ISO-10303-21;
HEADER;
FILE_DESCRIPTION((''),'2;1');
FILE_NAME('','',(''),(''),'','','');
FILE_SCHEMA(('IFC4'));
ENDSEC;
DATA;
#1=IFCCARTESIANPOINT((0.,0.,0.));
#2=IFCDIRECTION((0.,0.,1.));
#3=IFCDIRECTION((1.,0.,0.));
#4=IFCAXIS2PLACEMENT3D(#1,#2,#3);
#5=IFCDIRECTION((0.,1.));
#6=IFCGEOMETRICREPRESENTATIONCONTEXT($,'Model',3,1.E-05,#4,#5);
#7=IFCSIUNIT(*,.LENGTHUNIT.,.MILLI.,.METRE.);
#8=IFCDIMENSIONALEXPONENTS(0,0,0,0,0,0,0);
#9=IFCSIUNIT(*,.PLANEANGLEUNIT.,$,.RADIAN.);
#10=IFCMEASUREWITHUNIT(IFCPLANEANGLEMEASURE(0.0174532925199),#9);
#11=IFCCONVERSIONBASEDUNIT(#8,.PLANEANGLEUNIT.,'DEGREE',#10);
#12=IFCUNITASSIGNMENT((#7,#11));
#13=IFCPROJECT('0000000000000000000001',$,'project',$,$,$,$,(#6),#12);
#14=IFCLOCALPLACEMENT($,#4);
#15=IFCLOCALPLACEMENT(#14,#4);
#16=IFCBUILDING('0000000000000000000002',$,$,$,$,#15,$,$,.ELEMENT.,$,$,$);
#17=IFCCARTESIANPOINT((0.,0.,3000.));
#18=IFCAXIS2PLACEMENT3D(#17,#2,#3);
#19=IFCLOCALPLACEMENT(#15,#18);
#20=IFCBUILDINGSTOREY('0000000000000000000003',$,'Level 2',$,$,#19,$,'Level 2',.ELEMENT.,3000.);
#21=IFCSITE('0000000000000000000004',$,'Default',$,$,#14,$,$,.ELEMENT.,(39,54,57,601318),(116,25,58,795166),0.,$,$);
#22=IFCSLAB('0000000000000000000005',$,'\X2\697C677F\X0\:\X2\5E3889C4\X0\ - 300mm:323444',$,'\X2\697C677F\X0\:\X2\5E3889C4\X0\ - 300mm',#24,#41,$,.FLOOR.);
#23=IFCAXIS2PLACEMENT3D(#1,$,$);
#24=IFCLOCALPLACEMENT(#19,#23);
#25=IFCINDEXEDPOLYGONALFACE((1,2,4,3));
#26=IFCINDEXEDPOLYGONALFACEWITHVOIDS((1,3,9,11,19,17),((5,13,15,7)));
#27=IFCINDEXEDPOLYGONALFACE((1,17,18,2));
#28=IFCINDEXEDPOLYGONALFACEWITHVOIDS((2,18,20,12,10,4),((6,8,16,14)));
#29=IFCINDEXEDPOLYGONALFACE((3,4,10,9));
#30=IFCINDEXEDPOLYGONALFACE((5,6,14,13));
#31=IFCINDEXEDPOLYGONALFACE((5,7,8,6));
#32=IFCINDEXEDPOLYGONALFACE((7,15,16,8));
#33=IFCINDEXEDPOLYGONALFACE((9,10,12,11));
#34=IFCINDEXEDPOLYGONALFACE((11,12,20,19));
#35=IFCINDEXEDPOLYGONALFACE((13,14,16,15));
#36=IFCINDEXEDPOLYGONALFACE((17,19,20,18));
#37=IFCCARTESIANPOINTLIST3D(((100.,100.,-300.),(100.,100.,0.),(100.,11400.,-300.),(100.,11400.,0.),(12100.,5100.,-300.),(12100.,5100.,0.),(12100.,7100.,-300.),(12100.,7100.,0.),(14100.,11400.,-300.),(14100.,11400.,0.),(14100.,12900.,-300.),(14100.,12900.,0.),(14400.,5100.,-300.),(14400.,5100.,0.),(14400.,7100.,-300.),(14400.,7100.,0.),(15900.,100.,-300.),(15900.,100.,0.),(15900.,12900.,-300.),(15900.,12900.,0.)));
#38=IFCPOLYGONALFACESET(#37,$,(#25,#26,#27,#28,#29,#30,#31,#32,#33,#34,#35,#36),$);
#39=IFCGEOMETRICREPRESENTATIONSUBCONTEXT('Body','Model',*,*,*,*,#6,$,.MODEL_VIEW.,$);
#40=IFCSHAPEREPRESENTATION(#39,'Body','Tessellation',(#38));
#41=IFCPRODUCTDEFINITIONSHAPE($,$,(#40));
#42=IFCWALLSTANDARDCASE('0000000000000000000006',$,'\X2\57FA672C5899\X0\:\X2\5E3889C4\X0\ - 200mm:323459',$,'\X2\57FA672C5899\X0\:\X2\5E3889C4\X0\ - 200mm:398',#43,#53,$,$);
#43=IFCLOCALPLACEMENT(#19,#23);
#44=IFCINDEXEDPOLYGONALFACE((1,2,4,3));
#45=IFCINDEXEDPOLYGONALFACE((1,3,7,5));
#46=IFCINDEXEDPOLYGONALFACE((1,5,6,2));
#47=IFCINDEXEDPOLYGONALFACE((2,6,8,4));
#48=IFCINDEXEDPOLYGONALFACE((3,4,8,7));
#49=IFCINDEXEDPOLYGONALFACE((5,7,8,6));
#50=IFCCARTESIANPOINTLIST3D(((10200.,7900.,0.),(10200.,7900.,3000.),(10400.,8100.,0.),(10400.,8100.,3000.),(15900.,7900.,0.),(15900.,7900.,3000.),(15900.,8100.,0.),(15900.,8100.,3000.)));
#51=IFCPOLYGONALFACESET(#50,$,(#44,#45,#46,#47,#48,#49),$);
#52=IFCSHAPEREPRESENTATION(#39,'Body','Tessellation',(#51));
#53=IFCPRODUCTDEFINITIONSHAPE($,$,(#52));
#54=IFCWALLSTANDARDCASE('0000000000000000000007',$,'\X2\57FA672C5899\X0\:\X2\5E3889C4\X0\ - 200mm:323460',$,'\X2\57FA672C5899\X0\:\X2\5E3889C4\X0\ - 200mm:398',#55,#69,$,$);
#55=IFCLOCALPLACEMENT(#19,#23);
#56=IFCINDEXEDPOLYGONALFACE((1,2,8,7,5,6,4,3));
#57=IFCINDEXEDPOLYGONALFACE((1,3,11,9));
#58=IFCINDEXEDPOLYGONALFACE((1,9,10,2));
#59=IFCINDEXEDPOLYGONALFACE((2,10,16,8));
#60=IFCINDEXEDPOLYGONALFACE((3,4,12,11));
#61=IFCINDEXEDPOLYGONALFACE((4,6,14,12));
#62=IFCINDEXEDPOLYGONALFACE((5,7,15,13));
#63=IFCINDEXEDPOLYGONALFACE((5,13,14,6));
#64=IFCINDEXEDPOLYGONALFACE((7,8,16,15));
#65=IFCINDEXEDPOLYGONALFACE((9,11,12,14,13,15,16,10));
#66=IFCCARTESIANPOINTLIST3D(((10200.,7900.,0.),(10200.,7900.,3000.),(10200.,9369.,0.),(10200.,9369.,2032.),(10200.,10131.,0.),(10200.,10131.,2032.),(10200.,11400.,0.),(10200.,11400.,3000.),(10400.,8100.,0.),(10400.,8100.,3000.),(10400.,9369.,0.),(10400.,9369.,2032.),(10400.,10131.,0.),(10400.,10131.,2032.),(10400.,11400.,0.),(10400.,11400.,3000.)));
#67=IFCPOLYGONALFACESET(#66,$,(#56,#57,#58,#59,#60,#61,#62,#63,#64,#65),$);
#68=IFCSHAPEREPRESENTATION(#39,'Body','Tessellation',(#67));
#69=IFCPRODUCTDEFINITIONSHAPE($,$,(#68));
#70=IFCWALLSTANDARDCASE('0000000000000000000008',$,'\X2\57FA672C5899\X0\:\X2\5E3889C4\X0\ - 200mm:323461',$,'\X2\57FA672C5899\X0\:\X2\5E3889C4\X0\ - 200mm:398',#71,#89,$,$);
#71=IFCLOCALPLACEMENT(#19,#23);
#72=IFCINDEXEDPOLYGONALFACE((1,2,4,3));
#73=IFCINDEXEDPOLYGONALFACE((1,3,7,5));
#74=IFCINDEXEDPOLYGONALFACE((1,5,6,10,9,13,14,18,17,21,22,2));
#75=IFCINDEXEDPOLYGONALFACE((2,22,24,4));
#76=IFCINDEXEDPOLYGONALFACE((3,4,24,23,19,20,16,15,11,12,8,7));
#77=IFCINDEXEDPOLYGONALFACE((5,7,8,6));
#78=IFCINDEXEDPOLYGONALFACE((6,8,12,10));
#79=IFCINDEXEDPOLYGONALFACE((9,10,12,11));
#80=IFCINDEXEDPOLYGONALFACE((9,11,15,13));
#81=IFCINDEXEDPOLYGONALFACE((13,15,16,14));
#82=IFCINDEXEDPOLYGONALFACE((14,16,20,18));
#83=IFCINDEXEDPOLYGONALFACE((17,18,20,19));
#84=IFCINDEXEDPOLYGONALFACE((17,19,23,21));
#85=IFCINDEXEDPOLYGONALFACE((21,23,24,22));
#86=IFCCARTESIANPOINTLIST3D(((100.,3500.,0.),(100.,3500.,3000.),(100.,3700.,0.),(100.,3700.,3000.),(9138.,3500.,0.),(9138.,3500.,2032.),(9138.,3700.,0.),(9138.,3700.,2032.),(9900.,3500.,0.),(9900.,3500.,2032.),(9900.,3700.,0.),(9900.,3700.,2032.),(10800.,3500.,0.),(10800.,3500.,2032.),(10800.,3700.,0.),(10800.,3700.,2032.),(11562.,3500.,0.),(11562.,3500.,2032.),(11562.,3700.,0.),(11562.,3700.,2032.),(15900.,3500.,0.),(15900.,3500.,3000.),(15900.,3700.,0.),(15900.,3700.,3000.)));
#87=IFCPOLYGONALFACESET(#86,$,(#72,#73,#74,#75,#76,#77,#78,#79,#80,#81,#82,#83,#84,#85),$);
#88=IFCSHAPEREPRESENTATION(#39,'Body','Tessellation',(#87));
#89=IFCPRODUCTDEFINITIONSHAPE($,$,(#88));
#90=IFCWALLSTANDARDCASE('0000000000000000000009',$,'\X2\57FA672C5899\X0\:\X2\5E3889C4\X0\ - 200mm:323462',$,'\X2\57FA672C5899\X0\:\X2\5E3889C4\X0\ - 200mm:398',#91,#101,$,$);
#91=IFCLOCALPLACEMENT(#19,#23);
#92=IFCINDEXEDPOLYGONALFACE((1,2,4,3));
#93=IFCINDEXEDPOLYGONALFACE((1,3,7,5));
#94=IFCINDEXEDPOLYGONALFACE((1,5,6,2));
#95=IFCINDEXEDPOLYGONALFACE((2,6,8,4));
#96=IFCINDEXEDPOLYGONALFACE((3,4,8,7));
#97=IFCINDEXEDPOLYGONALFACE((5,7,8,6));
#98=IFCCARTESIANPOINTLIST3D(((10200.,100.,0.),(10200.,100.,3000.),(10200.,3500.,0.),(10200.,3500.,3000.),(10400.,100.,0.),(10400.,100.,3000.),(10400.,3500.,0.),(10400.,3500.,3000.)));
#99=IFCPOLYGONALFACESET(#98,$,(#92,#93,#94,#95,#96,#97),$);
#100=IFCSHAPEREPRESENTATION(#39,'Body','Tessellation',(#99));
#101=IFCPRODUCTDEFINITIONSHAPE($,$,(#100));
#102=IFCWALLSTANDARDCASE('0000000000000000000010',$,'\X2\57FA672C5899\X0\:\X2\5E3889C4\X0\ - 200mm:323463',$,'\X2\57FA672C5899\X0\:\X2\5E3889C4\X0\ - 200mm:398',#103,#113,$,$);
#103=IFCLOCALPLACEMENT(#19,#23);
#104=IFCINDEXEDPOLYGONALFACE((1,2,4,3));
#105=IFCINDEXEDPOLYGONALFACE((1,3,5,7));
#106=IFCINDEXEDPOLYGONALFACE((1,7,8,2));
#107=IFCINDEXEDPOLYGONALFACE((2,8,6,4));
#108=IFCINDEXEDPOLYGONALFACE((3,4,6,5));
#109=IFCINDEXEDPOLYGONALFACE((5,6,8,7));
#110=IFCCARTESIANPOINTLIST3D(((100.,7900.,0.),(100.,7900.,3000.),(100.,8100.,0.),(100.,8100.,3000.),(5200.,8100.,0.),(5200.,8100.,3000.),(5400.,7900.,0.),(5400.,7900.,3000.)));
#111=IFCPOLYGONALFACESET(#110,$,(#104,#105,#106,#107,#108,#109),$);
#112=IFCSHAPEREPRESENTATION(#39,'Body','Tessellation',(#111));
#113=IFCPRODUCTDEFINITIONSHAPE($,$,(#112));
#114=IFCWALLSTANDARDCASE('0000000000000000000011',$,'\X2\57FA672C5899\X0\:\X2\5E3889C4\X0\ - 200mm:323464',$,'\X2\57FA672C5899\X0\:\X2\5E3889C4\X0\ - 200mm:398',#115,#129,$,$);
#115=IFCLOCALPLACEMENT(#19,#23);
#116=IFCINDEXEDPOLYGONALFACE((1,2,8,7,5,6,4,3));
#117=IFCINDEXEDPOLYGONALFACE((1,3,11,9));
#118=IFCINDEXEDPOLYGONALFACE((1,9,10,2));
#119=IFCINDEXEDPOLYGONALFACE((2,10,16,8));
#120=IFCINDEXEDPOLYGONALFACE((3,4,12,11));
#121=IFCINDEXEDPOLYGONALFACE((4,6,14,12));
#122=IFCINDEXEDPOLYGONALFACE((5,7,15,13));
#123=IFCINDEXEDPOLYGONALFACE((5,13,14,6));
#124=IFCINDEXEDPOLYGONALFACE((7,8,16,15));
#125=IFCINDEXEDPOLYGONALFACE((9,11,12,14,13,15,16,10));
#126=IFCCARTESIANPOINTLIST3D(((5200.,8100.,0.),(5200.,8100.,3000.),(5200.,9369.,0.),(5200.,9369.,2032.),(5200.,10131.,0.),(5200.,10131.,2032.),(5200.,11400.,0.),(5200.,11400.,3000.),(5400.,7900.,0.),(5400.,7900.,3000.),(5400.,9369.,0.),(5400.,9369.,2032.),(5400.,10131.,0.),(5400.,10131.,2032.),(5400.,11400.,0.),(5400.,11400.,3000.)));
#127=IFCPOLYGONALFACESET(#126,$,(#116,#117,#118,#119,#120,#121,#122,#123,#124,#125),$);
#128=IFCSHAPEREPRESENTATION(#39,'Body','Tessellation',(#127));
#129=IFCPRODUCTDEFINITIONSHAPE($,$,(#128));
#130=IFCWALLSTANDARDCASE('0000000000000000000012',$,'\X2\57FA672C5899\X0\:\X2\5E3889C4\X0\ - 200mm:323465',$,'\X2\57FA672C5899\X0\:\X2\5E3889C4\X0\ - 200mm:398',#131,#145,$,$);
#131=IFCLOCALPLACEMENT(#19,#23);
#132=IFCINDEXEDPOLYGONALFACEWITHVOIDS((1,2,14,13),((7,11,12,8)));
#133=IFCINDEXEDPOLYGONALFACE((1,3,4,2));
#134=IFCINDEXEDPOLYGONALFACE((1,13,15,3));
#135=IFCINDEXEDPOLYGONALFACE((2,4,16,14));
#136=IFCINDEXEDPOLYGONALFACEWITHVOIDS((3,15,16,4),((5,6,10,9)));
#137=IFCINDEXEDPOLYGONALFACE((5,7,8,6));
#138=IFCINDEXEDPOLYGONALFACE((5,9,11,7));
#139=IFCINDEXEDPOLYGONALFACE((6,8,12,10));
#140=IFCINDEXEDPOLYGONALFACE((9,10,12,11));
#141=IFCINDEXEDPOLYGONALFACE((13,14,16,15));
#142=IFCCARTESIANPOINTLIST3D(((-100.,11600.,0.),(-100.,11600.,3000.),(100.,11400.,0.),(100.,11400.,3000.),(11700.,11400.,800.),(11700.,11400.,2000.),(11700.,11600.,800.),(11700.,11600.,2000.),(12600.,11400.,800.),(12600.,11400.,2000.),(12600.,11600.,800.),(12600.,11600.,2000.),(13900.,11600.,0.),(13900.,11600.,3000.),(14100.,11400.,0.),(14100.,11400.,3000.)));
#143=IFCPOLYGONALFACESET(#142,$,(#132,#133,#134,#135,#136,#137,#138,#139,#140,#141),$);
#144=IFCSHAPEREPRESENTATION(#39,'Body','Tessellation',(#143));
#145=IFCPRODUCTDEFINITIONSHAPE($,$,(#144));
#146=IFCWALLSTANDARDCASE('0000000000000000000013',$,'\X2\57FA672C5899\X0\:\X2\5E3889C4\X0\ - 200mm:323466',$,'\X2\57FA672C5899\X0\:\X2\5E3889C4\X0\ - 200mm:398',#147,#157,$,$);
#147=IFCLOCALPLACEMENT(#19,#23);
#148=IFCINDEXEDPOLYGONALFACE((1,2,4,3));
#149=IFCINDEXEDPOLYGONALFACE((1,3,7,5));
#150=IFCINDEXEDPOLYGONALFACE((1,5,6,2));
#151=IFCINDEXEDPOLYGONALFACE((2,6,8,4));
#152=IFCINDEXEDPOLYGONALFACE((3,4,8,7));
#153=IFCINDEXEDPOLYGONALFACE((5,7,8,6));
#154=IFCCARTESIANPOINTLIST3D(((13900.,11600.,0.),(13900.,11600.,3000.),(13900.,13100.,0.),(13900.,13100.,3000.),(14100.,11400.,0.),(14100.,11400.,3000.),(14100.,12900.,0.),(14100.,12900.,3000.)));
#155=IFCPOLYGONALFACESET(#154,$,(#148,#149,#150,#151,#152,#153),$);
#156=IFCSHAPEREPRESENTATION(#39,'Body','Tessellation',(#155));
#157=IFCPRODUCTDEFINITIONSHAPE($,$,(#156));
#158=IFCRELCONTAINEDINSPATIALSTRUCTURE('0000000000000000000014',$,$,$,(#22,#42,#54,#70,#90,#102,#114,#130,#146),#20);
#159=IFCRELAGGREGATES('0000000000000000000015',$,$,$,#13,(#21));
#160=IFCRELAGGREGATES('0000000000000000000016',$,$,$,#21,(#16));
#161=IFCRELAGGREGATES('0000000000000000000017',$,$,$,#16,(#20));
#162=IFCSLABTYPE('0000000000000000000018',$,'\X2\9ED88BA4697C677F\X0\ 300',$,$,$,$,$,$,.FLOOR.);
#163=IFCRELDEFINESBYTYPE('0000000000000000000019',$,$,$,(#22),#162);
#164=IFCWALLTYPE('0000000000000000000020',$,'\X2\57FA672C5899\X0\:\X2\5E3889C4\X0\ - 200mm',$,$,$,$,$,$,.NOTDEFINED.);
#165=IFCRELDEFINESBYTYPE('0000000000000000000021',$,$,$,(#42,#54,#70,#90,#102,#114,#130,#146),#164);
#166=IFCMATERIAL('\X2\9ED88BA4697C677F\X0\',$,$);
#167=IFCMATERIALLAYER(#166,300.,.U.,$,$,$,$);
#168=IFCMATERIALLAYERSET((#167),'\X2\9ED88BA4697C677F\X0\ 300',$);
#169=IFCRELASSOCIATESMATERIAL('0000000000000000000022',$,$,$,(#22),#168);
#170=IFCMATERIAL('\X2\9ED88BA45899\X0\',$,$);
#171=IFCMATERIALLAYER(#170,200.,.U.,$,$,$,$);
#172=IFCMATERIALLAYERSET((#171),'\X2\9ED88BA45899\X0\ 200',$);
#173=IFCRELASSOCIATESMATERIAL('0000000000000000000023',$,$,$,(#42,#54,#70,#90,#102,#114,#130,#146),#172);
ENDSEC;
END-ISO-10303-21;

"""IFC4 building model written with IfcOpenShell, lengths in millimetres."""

from ifc_helpers import new_model, entity, si_unit, converted_unit, direction, frame, origin_with_axes, place, context, subcontext, project, spatial, polyline, outline, extrude, material, layer, layer_set, layer_usage, type_object, element, save


model = new_model("IFC4")

# Units and contexts
model_context = context("Model", 3, precision=1e-05, world=origin_with_axes(), true_north=direction((0.0, 1.0)))
body_context = subcontext(model_context, "Body", "Model", "MODEL_VIEW")
ifc_project = project(units=[si_unit("LENGTHUNIT", "METRE", prefix="MILLI"), converted_unit("PLANEANGLEUNIT", "DEGREE", entity("IfcPlaneAngleMeasure", 0.0174532925199), si_unit("PLANEANGLEUNIT", "RADIAN"), dimensions=[0, 0, 0, 0, 0, 0, 0])], contexts=[model_context])

# Site, building, storey
site_placement = place(None, origin_with_axes())
site = spatial("IfcSite", under=ifc_project, at=site_placement, Name="Default", CompositionType="ELEMENT", RefLatitude=(39, 54, 57, 601318), RefLongitude=(116, 25, 58, 795166), RefElevation=0.0)
building_placement = place(site_placement, origin_with_axes())
building = spatial("IfcBuilding", under=site, at=building_placement, CompositionType="ELEMENT")
storey_placement = place(building_placement, frame((0.0, 0.0, 3000.0), z_axis=(0.0, 0.0, 1.0), x_axis=(1.0, 0.0, 0.0)))
storey = spatial("IfcBuildingStorey", under=building, at=storey_placement, Name="Level 2", LongName="Level 2", CompositionType="ELEMENT", Elevation=3000.0)

# Slab, opening
ifc_material_1 = material(Name="默认楼板")
ifc_layer_1 = layer(ifc_material_1, 300.0, ventilated="UNKNOWN")
ifc_layer_set_1 = layer_set([ifc_layer_1], Name="默认楼板 300")
ifc_layer_usage_1 = layer_usage(ifc_layer_set_1, "AXIS3", "NEGATIVE", 300.0)
slab_type = type_object("IfcSlabType", Name="默认楼板 300", PredefinedType="FLOOR")
slab_placement = place(storey_placement, frame((15900.0, 12900.0, -300.0), z_axis=(0.0, 0.0, 1.0), x_axis=(1.0, 0.0, 0.0)))
slab = element("IfcSlab", 1, at=slab_placement, inside=storey, type_object=slab_type, material=ifc_layer_usage_1, Name="楼板:常规 - 300mm:323444", ObjectType="楼板:常规 - 300mm", PredefinedType="FLOOR", context=body_context, shape_type="SweptSolid", body=[
    extrude(outline(polyline([(0.0, 0.0), (-1800.0, 0.0), (-1800.0, -1500.0), (-15800.0, -1500.0), (-15800.0, -12800.0), (0.0, -12800.0), (0.0, 0.0)])), origin_with_axes(), (0.0, 0.0, 1.0), 300.0),
])
opening_1_placement = place(slab_placement, origin_with_axes())
element("IfcOpeningElement", 2, at=opening_1_placement, cuts=slab, context=body_context, shape_type="SweptSolid", body=[
    extrude(outline(polyline([(-3800.0, -7800.0), (-1500.0, -7800.0), (-1500.0, -5800.0), (-3800.0, -5800.0), (-3800.0, -7800.0)])), origin_with_axes(), (0.0, 0.0, 1.0), 300.0),
])

# Wall
ifc_material_2 = material(Name="默认墙")
ifc_layer_2 = layer(ifc_material_2, 200.0, ventilated="UNKNOWN")
ifc_layer_set_2 = layer_set([ifc_layer_2], Name="默认墙 200")
ifc_layer_usage_2 = layer_usage(ifc_layer_set_2, "AXIS2", "POSITIVE", -100.0)
wall_type = type_object("IfcWallType", Name="基本墙:常规 - 200mm", PredefinedType="NOTDEFINED")
wall_1_placement = place(storey_placement, frame((10300.0, 8000.0, 0.0), z_axis=(0.0, 0.0, 1.0), x_axis=(1.0, 0.0, 0.0)))
element("IfcWallStandardCase", 3, at=wall_1_placement, inside=storey, type_object=wall_type, material=ifc_layer_usage_2, Name="基本墙:常规 - 200mm:323459", ObjectType="基本墙:常规 - 200mm:398", context=body_context, shape_type="SweptSolid", body=[
    extrude(outline(polyline([(-100.0, -100.0), (5600.0, -100.0), (5600.0, 100.0), (100.0, 100.0), (-100.0, -100.0)])), origin_with_axes(), (0.0, 0.0, 1.0), 3000.0),
])

# Wall, opening
ifc_layer_usage_3 = layer_usage(ifc_layer_set_2, "AXIS2", "POSITIVE", -100.0)
wall_2_placement = place(storey_placement, frame((10300.0, 11500.0, 0.0), z_axis=(0.0, 0.0, 1.0), x_axis=(0.0, -1.0, 0.0)))
wall_2 = element("IfcWallStandardCase", 4, at=wall_2_placement, inside=storey, type_object=wall_type, material=ifc_layer_usage_3, Name="基本墙:常规 - 200mm:323460", ObjectType="基本墙:常规 - 200mm:398", context=body_context, shape_type="SweptSolid", body=[
    extrude(outline(polyline([(100.0, -100.0), (3600.0, -100.0), (3400.0, 100.0), (100.0, 100.0), (100.0, -100.0)])), origin_with_axes(), (0.0, 0.0, 1.0), 3000.0),
])
opening_2_placement = place(wall_2_placement, frame((1750.0, 0.0, 0.0), z_axis=(0.0, 0.0, 1.0), x_axis=(1.0, 0.0, 0.0)))
element("IfcOpeningElement", 5, at=opening_2_placement, cuts=wall_2, context=body_context, shape_type="SweptSolid", body=[
    extrude(outline(polyline([(-381.0, -2032.0), (381.0, -2032.0), (381.0, 0.0), (-381.0, 0.0), (-381.0, -2032.0)])), frame((0.0, 100.0, 0.0), z_axis=(0.0, -1.0, 0.0), x_axis=(-1.0, 0.0, 0.0)), (0.0, 0.0, 1.0), 200.0),
])

# Wall, openings
ifc_layer_usage_4 = layer_usage(ifc_layer_set_2, "AXIS2", "POSITIVE", -100.0)
wall_3_placement = place(storey_placement, frame((16000.0, 3600.0, 0.0), z_axis=(0.0, 0.0, 1.0), x_axis=(-1.0, 0.0, 0.0)))
wall_3 = element("IfcWallStandardCase", 6, at=wall_3_placement, inside=storey, type_object=wall_type, material=ifc_layer_usage_4, Name="基本墙:常规 - 200mm:323461", ObjectType="基本墙:常规 - 200mm:398", context=body_context, shape_type="SweptSolid", body=[
    extrude(outline(polyline([(100.0, -100.0), (15900.0, -100.0), (15900.0, 100.0), (100.0, 100.0), (100.0, -100.0)])), origin_with_axes(), (0.0, 0.0, 1.0), 3000.0),
])
opening_3_placement = place(wall_3_placement, frame((6481.0, 0.0, 0.0), z_axis=(0.0, 0.0, 1.0), x_axis=(1.0, 0.0, 0.0)))
element("IfcOpeningElement", 7, at=opening_3_placement, cuts=wall_3, context=body_context, shape_type="SweptSolid", body=[
    extrude(outline(polyline([(-381.0, 0.0), (-381.0, -2032.0), (381.0, -2032.0), (381.0, 0.0), (-381.0, 0.0)])), frame((0.0, 100.0, 0.0), z_axis=(0.0, 1.0, 0.0), x_axis=(1.0, 0.0, 0.0)), (0.0, 0.0, -1.0), 200.0),
])
opening_4_placement = place(wall_3_placement, frame((4819.0, 0.0, 0.0), z_axis=(0.0, 0.0, 1.0), x_axis=(1.0, 0.0, 0.0)))
element("IfcOpeningElement", 8, at=opening_4_placement, cuts=wall_3, context=body_context, shape_type="SweptSolid", body=[
    extrude(outline(polyline([(-381.0, -2032.0), (381.0, -2032.0), (381.0, 0.0), (-381.0, 0.0), (-381.0, -2032.0)])), frame((0.0, 100.0, 0.0), z_axis=(0.0, -1.0, 0.0), x_axis=(-1.0, 0.0, 0.0)), (0.0, 0.0, 1.0), 200.0),
])

# Walls
ifc_layer_usage_5 = layer_usage(ifc_layer_set_2, "AXIS2", "POSITIVE", -100.0)
wall_4_placement = place(storey_placement, frame((10300.0, 3600.0, 0.0), z_axis=(0.0, 0.0, 1.0), x_axis=(0.0, -1.0, 0.0)))
element("IfcWallStandardCase", 9, at=wall_4_placement, inside=storey, type_object=wall_type, material=ifc_layer_usage_5, Name="基本墙:常规 - 200mm:323462", ObjectType="基本墙:常规 - 200mm:398", context=body_context, shape_type="SweptSolid", body=[
    extrude(outline(polyline([(100.0, -100.0), (3500.0, -100.0), (3500.0, 100.0), (100.0, 100.0), (100.0, -100.0)])), origin_with_axes(), (0.0, 0.0, 1.0), 3000.0),
])
ifc_layer_usage_6 = layer_usage(ifc_layer_set_2, "AXIS2", "POSITIVE", -100.0)
wall_5_placement = place(storey_placement, frame((0.0, 8000.0, 0.0), z_axis=(0.0, 0.0, 1.0), x_axis=(1.0, 0.0, 0.0)))
element("IfcWallStandardCase", 10, at=wall_5_placement, inside=storey, type_object=wall_type, material=ifc_layer_usage_6, Name="基本墙:常规 - 200mm:323463", ObjectType="基本墙:常规 - 200mm:398", context=body_context, shape_type="SweptSolid", body=[
    extrude(outline(polyline([(100.0, -100.0), (5400.0, -100.0), (5200.0, 100.0), (100.0, 100.0), (100.0, -100.0)])), origin_with_axes(), (0.0, 0.0, 1.0), 3000.0),
])

# Walls, openings
ifc_layer_usage_7 = layer_usage(ifc_layer_set_2, "AXIS2", "POSITIVE", -100.0)
wall_6_placement = place(storey_placement, frame((5300.0, 8000.0, 0.0), z_axis=(0.0, 0.0, 1.0), x_axis=(0.0, 1.0, 0.0)))
wall_6 = element("IfcWallStandardCase", 11, at=wall_6_placement, inside=storey, type_object=wall_type, material=ifc_layer_usage_7, Name="基本墙:常规 - 200mm:323464", ObjectType="基本墙:常规 - 200mm:398", context=body_context, shape_type="SweptSolid", body=[
    extrude(outline(polyline([(-100.0, -100.0), (3400.0, -100.0), (3400.0, 100.0), (100.0, 100.0), (-100.0, -100.0)])), origin_with_axes(), (0.0, 0.0, 1.0), 3000.0),
])
opening_5_placement = place(wall_6_placement, frame((1750.0, 0.0, 0.0), z_axis=(0.0, 0.0, 1.0), x_axis=(1.0, 0.0, 0.0)))
element("IfcOpeningElement", 12, at=opening_5_placement, cuts=wall_6, context=body_context, shape_type="SweptSolid", body=[
    extrude(outline(polyline([(-381.0, -2032.0), (381.0, -2032.0), (381.0, 0.0), (-381.0, 0.0), (-381.0, -2032.0)])), frame((0.0, 100.0, 0.0), z_axis=(0.0, -1.0, 0.0), x_axis=(-1.0, 0.0, 0.0)), (0.0, 0.0, 1.0), 200.0),
])
ifc_layer_usage_8 = layer_usage(ifc_layer_set_2, "AXIS2", "POSITIVE", -100.0)
wall_7_placement = place(storey_placement, frame((0.0, 11500.0, 0.0), z_axis=(0.0, 0.0, 1.0), x_axis=(1.0, 0.0, 0.0)))
wall_7 = element("IfcWallStandardCase", 13, at=wall_7_placement, inside=storey, type_object=wall_type, material=ifc_layer_usage_8, Name="基本墙:常规 - 200mm:323465", ObjectType="基本墙:常规 - 200mm:398", context=body_context, shape_type="SweptSolid", body=[
    extrude(outline(polyline([(100.0, -100.0), (14100.0, -100.0), (13900.0, 100.0), (-100.0, 100.0), (100.0, -100.0)])), origin_with_axes(), (0.0, 0.0, 1.0), 3000.0),
])
opening_6_placement = place(wall_7_placement, frame((12150.0, 0.0, 800.0), z_axis=(0.0, 0.0, 1.0), x_axis=(1.0, 0.0, 0.0)))
element("IfcOpeningElement", 14, at=opening_6_placement, cuts=wall_7, context=body_context, shape_type="SweptSolid", body=[
    extrude(outline(polyline([(450.0, -1200.0), (450.0, 0.0), (-450.0, 0.0), (-450.0, -1200.0), (450.0, -1200.0)])), frame((0.0, 100.0, 0.0), z_axis=(0.0, -1.0, 0.0), x_axis=(-1.0, 0.0, 0.0)), (0.0, 0.0, 1.0), 200.0),
])

# Wall
ifc_layer_usage_9 = layer_usage(ifc_layer_set_2, "AXIS2", "POSITIVE", -100.0)
wall_8_placement = place(storey_placement, frame((14000.0, 11500.0, 0.0), z_axis=(0.0, 0.0, 1.0), x_axis=(0.0, 1.0, 0.0)))
element("IfcWallStandardCase", 15, at=wall_8_placement, inside=storey, type_object=wall_type, material=ifc_layer_usage_9, Name="基本墙:常规 - 200mm:323466", ObjectType="基本墙:常规 - 200mm:398", context=body_context, shape_type="SweptSolid", body=[
    extrude(outline(polyline([(-100.0, -100.0), (1400.0, -100.0), (1600.0, 100.0), (100.0, 100.0), (-100.0, -100.0)])), origin_with_axes(), (0.0, 0.0, 1.0), 3000.0),
])

save(model, "model.ifc")
